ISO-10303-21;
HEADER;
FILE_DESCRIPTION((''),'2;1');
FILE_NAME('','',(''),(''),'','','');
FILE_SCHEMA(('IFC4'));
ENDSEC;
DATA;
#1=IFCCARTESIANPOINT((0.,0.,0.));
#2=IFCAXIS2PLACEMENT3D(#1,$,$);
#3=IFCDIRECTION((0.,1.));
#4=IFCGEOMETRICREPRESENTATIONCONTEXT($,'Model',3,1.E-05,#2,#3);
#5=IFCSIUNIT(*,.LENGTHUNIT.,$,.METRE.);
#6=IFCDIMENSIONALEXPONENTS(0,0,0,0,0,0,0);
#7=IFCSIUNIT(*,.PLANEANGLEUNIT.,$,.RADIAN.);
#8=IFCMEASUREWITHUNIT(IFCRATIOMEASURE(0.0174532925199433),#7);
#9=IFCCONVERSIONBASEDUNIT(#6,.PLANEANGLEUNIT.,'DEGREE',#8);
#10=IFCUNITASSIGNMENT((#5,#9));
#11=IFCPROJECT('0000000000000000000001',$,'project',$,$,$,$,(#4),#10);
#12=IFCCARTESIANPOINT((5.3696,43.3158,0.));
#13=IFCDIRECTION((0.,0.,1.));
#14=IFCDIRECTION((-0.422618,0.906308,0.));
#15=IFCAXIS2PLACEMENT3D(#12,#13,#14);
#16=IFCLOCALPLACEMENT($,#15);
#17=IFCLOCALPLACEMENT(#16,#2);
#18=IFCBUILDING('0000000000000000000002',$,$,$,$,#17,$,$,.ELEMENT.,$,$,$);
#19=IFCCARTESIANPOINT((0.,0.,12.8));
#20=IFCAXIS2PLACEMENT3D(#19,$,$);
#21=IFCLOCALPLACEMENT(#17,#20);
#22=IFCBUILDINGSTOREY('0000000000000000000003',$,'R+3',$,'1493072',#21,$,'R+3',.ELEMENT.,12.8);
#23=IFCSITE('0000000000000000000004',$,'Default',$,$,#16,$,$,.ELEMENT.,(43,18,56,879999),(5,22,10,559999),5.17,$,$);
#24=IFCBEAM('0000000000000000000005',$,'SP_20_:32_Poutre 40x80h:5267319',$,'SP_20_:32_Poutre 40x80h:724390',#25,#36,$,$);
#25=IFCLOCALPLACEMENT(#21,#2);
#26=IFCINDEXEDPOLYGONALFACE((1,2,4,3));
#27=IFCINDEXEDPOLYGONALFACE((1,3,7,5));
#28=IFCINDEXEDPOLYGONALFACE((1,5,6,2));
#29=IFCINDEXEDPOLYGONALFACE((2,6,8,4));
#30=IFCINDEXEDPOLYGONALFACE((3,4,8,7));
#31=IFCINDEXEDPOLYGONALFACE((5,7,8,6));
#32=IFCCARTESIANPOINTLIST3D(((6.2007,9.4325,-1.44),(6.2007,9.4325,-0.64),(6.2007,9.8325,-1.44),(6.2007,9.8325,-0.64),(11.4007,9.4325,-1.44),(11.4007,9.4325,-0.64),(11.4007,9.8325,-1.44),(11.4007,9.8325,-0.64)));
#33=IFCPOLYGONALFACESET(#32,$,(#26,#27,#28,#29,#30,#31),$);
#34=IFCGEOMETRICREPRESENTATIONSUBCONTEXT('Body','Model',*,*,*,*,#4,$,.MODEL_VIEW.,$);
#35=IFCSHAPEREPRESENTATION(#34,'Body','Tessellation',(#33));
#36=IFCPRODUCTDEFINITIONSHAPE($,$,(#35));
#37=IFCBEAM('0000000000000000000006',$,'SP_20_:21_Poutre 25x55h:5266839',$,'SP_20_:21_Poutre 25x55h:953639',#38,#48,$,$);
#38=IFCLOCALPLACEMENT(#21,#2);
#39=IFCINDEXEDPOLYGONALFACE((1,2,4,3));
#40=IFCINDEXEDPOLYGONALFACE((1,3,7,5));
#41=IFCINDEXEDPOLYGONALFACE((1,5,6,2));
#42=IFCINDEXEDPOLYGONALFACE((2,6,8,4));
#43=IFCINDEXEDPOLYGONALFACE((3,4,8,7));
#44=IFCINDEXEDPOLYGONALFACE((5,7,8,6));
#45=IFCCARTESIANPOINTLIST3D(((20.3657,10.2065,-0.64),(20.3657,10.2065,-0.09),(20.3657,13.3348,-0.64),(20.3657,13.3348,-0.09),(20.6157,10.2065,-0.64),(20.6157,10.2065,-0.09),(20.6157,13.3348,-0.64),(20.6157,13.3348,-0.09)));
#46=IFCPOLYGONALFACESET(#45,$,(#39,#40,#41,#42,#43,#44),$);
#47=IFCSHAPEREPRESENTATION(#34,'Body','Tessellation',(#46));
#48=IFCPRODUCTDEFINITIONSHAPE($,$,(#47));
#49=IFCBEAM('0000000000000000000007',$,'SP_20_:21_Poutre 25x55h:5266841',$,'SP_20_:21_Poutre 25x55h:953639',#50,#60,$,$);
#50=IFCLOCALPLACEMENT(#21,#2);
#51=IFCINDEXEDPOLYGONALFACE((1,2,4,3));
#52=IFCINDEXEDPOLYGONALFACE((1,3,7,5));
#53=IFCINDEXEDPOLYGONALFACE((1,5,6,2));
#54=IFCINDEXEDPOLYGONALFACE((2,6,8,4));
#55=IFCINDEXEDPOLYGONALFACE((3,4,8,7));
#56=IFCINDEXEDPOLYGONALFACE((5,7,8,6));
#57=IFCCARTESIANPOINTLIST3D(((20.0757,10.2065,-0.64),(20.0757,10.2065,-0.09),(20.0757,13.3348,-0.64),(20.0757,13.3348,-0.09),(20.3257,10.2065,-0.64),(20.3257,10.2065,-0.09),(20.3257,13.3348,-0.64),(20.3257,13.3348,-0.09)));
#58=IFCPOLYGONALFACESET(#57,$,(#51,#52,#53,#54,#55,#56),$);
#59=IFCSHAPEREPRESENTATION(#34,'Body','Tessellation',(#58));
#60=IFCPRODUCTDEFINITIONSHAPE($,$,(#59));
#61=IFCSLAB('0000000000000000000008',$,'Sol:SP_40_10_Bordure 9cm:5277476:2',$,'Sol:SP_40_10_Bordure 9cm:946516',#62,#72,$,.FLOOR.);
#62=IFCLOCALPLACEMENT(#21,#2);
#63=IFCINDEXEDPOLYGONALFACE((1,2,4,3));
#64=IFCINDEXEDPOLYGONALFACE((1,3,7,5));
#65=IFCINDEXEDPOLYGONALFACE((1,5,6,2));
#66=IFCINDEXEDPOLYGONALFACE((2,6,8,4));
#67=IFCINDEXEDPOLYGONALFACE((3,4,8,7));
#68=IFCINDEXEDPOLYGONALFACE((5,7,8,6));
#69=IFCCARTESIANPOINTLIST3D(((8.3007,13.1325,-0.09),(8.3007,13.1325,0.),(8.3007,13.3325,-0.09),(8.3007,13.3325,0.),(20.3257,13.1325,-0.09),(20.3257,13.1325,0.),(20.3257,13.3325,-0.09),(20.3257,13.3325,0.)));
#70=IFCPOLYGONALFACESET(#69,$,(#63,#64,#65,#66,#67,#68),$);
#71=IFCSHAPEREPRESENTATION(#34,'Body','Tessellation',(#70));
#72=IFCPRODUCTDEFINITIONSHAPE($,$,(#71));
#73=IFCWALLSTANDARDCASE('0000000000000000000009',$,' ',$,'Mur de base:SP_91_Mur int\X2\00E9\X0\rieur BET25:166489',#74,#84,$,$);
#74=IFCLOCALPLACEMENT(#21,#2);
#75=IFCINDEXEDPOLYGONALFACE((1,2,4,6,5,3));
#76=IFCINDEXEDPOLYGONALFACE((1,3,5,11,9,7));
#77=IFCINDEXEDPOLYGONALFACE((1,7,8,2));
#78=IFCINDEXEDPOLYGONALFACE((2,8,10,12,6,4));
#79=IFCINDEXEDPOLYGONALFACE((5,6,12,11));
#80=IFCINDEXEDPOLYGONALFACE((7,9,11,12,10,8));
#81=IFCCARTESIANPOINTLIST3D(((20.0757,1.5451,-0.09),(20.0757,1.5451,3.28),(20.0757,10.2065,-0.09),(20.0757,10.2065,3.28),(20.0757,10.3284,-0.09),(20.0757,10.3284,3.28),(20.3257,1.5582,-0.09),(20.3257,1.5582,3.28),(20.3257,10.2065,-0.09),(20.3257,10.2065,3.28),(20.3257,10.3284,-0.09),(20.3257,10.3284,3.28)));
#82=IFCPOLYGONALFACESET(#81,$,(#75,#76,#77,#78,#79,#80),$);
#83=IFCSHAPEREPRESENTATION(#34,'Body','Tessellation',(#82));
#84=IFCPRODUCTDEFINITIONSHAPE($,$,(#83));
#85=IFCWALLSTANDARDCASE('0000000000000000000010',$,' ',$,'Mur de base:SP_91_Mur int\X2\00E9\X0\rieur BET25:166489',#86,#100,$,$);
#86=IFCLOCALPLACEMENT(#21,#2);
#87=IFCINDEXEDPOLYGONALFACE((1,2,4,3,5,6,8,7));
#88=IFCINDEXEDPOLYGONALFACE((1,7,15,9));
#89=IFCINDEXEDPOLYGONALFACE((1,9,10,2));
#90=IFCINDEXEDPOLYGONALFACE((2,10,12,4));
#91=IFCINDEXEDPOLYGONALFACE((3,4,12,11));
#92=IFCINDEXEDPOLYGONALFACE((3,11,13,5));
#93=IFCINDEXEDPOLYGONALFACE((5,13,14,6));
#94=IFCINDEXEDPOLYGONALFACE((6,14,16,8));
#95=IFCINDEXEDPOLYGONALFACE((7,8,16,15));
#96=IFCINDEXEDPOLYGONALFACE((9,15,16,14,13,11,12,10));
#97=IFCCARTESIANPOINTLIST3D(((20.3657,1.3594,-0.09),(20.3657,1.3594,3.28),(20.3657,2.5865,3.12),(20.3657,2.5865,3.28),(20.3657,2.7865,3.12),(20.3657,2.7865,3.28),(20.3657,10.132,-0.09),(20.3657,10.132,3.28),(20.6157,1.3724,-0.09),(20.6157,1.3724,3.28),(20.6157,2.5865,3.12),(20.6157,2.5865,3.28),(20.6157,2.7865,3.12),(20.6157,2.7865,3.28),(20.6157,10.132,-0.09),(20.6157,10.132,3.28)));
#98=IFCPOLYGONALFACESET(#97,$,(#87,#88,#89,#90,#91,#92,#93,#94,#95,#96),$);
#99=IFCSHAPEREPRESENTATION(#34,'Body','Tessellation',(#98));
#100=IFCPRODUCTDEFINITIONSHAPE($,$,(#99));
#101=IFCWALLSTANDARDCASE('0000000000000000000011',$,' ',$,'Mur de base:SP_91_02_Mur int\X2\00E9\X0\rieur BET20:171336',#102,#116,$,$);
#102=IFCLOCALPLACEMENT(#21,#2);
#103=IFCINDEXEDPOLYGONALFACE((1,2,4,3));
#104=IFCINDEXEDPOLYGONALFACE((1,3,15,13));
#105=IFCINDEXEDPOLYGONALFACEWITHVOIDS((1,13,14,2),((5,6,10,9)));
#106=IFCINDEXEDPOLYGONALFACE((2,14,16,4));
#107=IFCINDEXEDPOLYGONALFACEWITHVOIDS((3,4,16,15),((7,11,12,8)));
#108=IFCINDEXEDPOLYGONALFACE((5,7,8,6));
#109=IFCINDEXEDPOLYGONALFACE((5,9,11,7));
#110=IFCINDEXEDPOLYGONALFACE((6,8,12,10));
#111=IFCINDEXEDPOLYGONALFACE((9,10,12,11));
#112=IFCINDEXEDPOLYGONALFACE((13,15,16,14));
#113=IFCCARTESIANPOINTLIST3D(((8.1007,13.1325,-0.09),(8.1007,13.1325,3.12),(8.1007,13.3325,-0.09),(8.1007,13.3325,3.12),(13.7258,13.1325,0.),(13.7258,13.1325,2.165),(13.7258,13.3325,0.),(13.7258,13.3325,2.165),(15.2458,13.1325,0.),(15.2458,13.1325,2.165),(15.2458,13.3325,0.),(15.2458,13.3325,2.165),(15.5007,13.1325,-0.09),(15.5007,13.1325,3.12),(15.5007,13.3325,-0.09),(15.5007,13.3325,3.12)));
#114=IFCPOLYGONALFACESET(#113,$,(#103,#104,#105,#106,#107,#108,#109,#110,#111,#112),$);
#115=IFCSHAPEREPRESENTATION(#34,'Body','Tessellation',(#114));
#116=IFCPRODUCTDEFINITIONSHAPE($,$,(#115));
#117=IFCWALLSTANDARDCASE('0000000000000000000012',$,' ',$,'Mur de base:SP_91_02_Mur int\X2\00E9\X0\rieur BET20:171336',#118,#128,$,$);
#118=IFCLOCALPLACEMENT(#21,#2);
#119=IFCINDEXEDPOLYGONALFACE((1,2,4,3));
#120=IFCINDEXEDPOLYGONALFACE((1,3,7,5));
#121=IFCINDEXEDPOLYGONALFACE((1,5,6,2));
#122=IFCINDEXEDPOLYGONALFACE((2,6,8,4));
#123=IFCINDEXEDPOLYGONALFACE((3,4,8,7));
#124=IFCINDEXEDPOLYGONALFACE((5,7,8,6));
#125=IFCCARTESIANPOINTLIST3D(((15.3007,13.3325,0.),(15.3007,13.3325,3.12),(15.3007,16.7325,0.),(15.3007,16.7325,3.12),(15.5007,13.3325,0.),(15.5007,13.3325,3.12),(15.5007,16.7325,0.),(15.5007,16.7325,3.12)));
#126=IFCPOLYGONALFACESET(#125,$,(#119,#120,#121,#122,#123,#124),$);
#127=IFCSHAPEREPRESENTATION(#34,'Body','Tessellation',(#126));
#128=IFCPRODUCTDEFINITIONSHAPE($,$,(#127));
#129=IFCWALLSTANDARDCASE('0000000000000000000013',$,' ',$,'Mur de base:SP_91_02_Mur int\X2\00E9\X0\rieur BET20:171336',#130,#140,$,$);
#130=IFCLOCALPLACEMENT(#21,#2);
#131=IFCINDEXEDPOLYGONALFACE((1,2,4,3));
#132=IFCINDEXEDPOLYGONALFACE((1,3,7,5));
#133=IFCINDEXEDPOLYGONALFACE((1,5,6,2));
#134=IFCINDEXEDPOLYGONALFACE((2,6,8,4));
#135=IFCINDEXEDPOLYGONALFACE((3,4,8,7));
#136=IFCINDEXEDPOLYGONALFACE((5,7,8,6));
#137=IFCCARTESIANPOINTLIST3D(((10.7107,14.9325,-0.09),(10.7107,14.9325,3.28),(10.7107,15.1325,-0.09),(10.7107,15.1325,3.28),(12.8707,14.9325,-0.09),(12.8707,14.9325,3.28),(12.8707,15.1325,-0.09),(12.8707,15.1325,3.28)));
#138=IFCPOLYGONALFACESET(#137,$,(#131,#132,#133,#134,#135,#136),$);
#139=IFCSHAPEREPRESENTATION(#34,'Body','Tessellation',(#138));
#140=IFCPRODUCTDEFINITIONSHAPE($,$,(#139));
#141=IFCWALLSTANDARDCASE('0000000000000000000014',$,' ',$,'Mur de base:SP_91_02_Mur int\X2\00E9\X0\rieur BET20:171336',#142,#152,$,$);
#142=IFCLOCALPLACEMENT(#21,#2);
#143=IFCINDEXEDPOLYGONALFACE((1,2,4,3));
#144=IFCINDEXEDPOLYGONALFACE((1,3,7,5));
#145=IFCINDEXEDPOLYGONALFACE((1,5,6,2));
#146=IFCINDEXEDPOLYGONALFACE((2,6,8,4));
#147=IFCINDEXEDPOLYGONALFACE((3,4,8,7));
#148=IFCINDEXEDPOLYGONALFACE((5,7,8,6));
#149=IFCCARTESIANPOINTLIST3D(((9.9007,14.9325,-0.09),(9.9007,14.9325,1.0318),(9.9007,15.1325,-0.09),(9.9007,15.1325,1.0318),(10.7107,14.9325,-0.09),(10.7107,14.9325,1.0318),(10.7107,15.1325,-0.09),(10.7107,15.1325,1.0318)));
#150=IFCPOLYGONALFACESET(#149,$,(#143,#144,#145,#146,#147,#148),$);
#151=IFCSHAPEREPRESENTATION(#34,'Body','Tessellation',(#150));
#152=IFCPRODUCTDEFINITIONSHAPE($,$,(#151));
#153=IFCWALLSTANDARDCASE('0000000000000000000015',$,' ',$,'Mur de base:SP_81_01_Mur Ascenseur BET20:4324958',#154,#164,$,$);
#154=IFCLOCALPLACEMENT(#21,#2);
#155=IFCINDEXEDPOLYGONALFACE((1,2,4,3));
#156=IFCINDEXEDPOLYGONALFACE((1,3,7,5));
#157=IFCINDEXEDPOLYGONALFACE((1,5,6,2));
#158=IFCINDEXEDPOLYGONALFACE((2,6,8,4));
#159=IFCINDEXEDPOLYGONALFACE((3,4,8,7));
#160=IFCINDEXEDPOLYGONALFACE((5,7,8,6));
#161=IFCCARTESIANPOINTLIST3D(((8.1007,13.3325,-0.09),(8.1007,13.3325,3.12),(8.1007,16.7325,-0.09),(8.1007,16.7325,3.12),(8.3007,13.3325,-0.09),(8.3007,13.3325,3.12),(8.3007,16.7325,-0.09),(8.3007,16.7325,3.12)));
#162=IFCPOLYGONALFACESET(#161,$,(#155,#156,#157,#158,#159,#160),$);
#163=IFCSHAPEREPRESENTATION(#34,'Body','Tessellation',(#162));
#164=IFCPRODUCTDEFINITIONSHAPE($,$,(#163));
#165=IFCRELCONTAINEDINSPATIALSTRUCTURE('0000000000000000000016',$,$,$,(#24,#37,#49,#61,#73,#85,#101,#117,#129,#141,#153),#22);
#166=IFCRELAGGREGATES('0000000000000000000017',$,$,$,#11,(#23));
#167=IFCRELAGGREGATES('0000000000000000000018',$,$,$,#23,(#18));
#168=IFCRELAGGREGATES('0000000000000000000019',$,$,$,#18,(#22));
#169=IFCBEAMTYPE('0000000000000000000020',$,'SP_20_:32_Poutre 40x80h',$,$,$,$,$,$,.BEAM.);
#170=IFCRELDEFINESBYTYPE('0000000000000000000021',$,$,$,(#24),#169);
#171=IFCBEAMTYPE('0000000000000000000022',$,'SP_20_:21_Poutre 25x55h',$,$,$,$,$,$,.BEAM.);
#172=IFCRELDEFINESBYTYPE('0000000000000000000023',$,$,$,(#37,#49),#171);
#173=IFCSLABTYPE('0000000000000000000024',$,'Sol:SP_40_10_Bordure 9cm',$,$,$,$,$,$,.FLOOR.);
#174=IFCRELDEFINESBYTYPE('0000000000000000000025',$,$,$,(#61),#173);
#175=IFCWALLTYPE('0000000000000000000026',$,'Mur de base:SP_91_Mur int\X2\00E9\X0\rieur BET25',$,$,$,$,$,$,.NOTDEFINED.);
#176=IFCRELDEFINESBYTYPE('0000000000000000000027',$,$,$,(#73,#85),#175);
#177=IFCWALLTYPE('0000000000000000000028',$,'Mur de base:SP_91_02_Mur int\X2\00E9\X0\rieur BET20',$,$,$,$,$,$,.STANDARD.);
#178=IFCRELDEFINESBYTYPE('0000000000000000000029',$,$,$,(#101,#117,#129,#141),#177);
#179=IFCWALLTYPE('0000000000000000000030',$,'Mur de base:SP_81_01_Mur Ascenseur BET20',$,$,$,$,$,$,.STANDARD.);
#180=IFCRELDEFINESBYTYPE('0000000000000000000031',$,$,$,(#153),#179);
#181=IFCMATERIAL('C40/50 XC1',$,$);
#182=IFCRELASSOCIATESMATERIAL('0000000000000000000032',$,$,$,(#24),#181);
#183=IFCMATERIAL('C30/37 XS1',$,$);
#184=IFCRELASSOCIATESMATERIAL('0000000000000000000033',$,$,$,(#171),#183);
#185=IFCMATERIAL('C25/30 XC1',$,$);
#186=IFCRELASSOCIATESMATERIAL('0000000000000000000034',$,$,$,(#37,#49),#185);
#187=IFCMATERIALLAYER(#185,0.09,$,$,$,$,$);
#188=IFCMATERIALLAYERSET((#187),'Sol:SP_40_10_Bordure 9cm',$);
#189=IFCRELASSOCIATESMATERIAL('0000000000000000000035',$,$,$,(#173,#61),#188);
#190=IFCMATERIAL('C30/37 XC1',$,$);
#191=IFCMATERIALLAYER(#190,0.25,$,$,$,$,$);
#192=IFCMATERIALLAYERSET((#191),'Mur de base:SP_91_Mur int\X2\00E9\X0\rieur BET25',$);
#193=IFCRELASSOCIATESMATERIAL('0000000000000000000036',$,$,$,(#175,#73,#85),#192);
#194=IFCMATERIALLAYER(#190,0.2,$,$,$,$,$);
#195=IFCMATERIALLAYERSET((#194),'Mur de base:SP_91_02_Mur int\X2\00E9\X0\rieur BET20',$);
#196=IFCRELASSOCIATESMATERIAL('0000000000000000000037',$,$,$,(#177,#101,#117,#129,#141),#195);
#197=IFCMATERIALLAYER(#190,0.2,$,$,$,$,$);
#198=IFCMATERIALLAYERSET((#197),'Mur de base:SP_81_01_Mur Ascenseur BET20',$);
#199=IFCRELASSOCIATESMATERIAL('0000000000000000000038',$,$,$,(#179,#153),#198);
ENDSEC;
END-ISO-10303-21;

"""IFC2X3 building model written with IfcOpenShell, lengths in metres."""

from ifc_helpers import new_model, entity, si_unit, converted_unit, direction, frame, frame_2d, origin, origin_2d_with_axis, place, context, subcontext, project, spatial, polyline, rectangle, outline, extrude, clip, bounded_halfspace, material, layer, layer_set, layer_usage, type_object, element, save


model = new_model("IFC2X3")

# Units and contexts
model_context = context("Model", 3, precision=1e-05, world=origin(), true_north=direction((0.0, 1.0)))
body_context = subcontext(model_context, "Body", "Model", "MODEL_VIEW")
ifc_project = project(units=[si_unit("LENGTHUNIT", "METRE"), converted_unit("PLANEANGLEUNIT", "DEGREE", entity("IfcRatioMeasure", 0.0174532925199433), si_unit("PLANEANGLEUNIT", "RADIAN"), dimensions=[0, 0, 0, 0, 0, 0, 0])], contexts=[model_context])

# Site, building, storey
site_placement = place(None, frame((5.3696, 43.3158, 0.0), z_axis=(0.0, 0.0, 1.0), x_axis=(-0.422618, 0.906308, 0.0)))
site = spatial("IfcSite", under=ifc_project, at=site_placement, Name="Default", CompositionType="ELEMENT", RefLatitude=(43, 18, 56, 879999), RefLongitude=(5, 22, 10, 559999), RefElevation=5.17)
building_placement = place(site_placement, origin())
building = spatial("IfcBuilding", under=site, at=building_placement, CompositionType="ELEMENT")
storey_placement = place(building_placement, frame((0.0, 0.0, 12.8)))
storey = spatial("IfcBuildingStorey", under=building, at=storey_placement, Name="R+3", ObjectType="1493072", LongName="R+3", CompositionType="ELEMENT", Elevation=12.8)

# Beams
ifc_material_1 = material(Name="C40/50 XC1")
beam_type_1 = type_object("IfcBeamType", Name="SP_20_:32_Poutre 40x80h", PredefinedType="BEAM")
beam_1_placement = place(storey_placement, frame((11.4007, 9.6325, -0.64), z_axis=(0.0, 0.0, 1.0), x_axis=(-1.0, 0.0, 0.0)))
element("IfcBeam", 1, at=beam_1_placement, inside=storey, type_object=beam_type_1, material=ifc_material_1, Name="SP_20_:32_Poutre 40x80h:5267319", ObjectType="SP_20_:32_Poutre 40x80h:724390", context=body_context, shape_type="SweptSolid", body=[
    extrude(rectangle(XDim=0.8, YDim=0.4, at=frame_2d((0.0, 0.0), x_axis=(1.0, 0.0))), frame((0.0, 0.0, -0.4), z_axis=(1.0, 0.0, 0.0), x_axis=(0.0, 0.0, -1.0)), (0.0, 0.0, 1.0), 5.2),
])
ifc_material_2 = material(Name="C25/30 XC1")
ifc_material_3 = material(Name="C30/37 XS1")
beam_type_2 = type_object("IfcBeamType", Name="SP_20_:21_Poutre 25x55h", PredefinedType="BEAM", material=ifc_material_3)
beam_2_placement = place(storey_placement, frame((20.4907, 13.3221, -0.09), z_axis=(0.0, 0.0, 1.0), x_axis=(0.0, -1.0, 0.0)))
element("IfcBeam", 2, at=beam_2_placement, inside=storey, type_object=beam_type_2, material=ifc_material_2, Name="SP_20_:21_Poutre 25x55h:5266839", ObjectType="SP_20_:21_Poutre 25x55h:953639", context=body_context, shape_type="SweptSolid", body=[
    extrude(rectangle(XDim=0.55, YDim=0.25, at=origin_2d_with_axis()), frame((-0.0127, 0.0, -0.275), z_axis=(1.0, 0.0, 0.0), x_axis=(0.0, 0.0, -1.0)), (0.0, 0.0, 1.0), 3.1283),
])
beam_3_placement = place(storey_placement, frame((20.2007, 13.3221, -0.09), z_axis=(0.0, 0.0, 1.0), x_axis=(0.0, -1.0, 0.0)))
element("IfcBeam", 3, at=beam_3_placement, inside=storey, type_object=beam_type_2, material=ifc_material_2, Name="SP_20_:21_Poutre 25x55h:5266841", ObjectType="SP_20_:21_Poutre 25x55h:953639", context=body_context, shape_type="SweptSolid", body=[
    extrude(rectangle(XDim=0.55, YDim=0.25, at=frame_2d((0.0, 0.0), x_axis=(1.0, 0.0))), frame((-0.0127, 0.0, -0.275), z_axis=(1.0, 0.0, 0.0), x_axis=(0.0, 0.0, -1.0)), (0.0, 0.0, 1.0), 3.1283),
])

# Slab
ifc_layer_1 = layer(ifc_material_2, 0.09)
ifc_layer_set_1 = layer_set([ifc_layer_1], Name="Sol:SP_40_10_Bordure 9cm")
ifc_layer_usage_1 = layer_usage(ifc_layer_set_1, "AXIS3", "POSITIVE", 0.0)
slab_type = type_object("IfcSlabType", Name="Sol:SP_40_10_Bordure 9cm", PredefinedType="FLOOR", material=ifc_layer_set_1)
slab_1_placement = place(storey_placement, frame((8.3007, 13.1325, -0.09)))
element("IfcSlab", 4, at=slab_1_placement, inside=storey, type_object=slab_type, material=ifc_layer_usage_1, Name="Sol:SP_40_10_Bordure 9cm:5277476:2", ObjectType="Sol:SP_40_10_Bordure 9cm:946516", PredefinedType="FLOOR", context=body_context, shape_type="SweptSolid", body=[
    extrude(rectangle(XDim=12.025, YDim=0.2, at=frame_2d((13.075, 0.0), x_axis=(-1.0, 0.0))), frame((19.0875, 0.1, 0.09), z_axis=(0.0, 0.0, -1.0), x_axis=(-1.0, 0.0, 0.0)), (0.0, 0.0, 1.0), 0.09),
])

# Walls
ifc_material_4 = material(Name="C30/37 XC1")
ifc_layer_2 = layer(ifc_material_4, 0.25)
ifc_layer_set_2 = layer_set([ifc_layer_2], Name="Mur de base:SP_91_Mur intérieur BET25")
ifc_layer_usage_2 = layer_usage(ifc_layer_set_2, "AXIS2", "NEGATIVE", 0.125)
wall_type_1 = type_object("IfcWallType", Name="Mur de base:SP_91_Mur intérieur BET25", PredefinedType="NOTDEFINED", material=ifc_layer_set_2)
wall_1_placement = place(storey_placement, frame((20.2007, 10.3284, -0.09), z_axis=(0.0, 0.0, 1.0), x_axis=(0.0, -1.0, 0.0)))
element("IfcWallStandardCase", 5, at=wall_1_placement, inside=storey, type_object=wall_type_1, material=ifc_layer_usage_2, Name=" ", ObjectType="Mur de base:SP_91_Mur intérieur BET25:166489", context=body_context, shape_type="SweptSolid", body=[
    extrude(outline(polyline([(8.7833, -0.125), (8.7702, 0.125), (0.1219, 0.125), (0.0, 0.125), (0.0, -0.125), (0.1219, -0.125), (8.7833, -0.125)])), origin(), (0.0, 0.0, 1.0), 3.37),
])
ifc_layer_usage_3 = layer_usage(ifc_layer_set_2, "AXIS2", "NEGATIVE", 0.125)
wall_2_placement = place(storey_placement, frame((20.4907, 10.132, -0.09), z_axis=(0.0, 0.0, 1.0), x_axis=(0.0, -1.0, 0.0)))
element("IfcWallStandardCase", 6, at=wall_2_placement, inside=storey, type_object=wall_type_1, material=ifc_layer_usage_3, Name=" ", ObjectType="Mur de base:SP_91_Mur intérieur BET25:166489", context=body_context, shape_type="Clipping", body=[
    clip(extrude(outline(polyline([(8.7726, -0.125), (8.7596, 0.125), (8.5593, 0.125), (0.0, 0.125), (0.0, -0.125), (8.7726, -0.125)])), origin(), (0.0, 0.0, 1.0), 3.37), bounded_halfspace(frame((7.3455, 0.125, 3.21), z_axis=(0.0, 0.0, -1.0), x_axis=(1.0, 0.0, 0.0)), True, frame((7.3455, 0.125, 3.21), z_axis=(0.0, 0.0, -1.0), x_axis=(1.0, 0.0, 0.0)), polyline([(0.0, 0.0), (0.2, 0.0), (0.2, 0.25), (0.0, 0.25), (0.0, 0.0)]))),
])

# Wall, opening
ifc_layer_3 = layer(ifc_material_4, 0.2)
ifc_layer_set_3 = layer_set([ifc_layer_3], Name="Mur de base:SP_91_02_Mur intérieur BET20")
ifc_layer_usage_4 = layer_usage(ifc_layer_set_3, "AXIS2", "NEGATIVE", 0.1)
wall_type_2 = type_object("IfcWallType", Name="Mur de base:SP_91_02_Mur intérieur BET20", PredefinedType="STANDARD", material=ifc_layer_set_3)
wall_3_placement = place(storey_placement, frame((8.1007, 13.2325, -0.09)))
wall_3 = element("IfcWallStandardCase", 7, at=wall_3_placement, inside=storey, type_object=wall_type_2, material=ifc_layer_usage_4, Name=" ", ObjectType="Mur de base:SP_91_02_Mur intérieur BET20:171336", context=body_context, shape_type="Clipping", body=[
    clip(extrude(rectangle(XDim=7.4, YDim=0.2, at=frame_2d((3.7, 0.0), x_axis=(-1.0, 0.0))), origin(), (0.0, 0.0, 1.0), 3.21), bounded_halfspace(frame((0.0, -0.1, 3.21), z_axis=(0.0, 0.0, -1.0), x_axis=(1.0, 0.0, 0.0)), True, frame((0.0, -0.1, 3.21), z_axis=(0.0, 0.0, -1.0), x_axis=(1.0, 0.0, 0.0)), polyline([(0.0, 0.0), (0.0, -0.2), (0.2, -0.2), (7.2, -0.2), (7.4, -0.2), (7.4, 0.0), (0.0, 0.0)]))),
])
opening_1_placement = place(wall_3_placement, origin())
element("IfcOpeningElement", 8, at=opening_1_placement, cuts=wall_3, ObjectType="Opening", context=body_context, shape_type="SweptSolid", body=[
    extrude(rectangle(XDim=2.165, YDim=1.52, at=frame_2d((0.0, 0.0), x_axis=(1.0, 0.0))), frame((6.3851, -1.424, 1.1725), z_axis=(0.0, 1.0, 0.0), x_axis=(0.0, 0.0, -1.0)), (0.0, 0.0, 1.0), 3.048),
])

# Walls
ifc_layer_usage_5 = layer_usage(ifc_layer_set_3, "AXIS2", "NEGATIVE", 0.1)
wall_4_placement = place(storey_placement, frame((15.4007, 13.3325, 0.0), z_axis=(0.0, 0.0, 1.0), x_axis=(0.0, 1.0, 0.0)))
element("IfcWallStandardCase", 9, at=wall_4_placement, inside=storey, type_object=wall_type_2, material=ifc_layer_usage_5, Name=" ", ObjectType="Mur de base:SP_91_02_Mur intérieur BET20:171336", context=body_context, shape_type="Clipping", body=[
    clip(clip(extrude(rectangle(XDim=3.4, YDim=0.2, at=frame_2d((1.7, 0.0), x_axis=(-1.0, 0.0))), origin(), (0.0, 0.0, 1.0), 3.12), bounded_halfspace(frame((3.4, -0.1, 3.12), z_axis=(0.0, 0.0, -1.0), x_axis=(1.0, 0.0, 0.0)), True, frame((3.4, -0.1, 3.12), z_axis=(0.0, 0.0, -1.0), x_axis=(1.0, 0.0, 0.0)), polyline([(0.0, 0.0), (-2.9141, 0.0), (-3.4, 0.0), (-3.4, -0.2), (0.0, -0.2), (0.0, 0.0)]))), bounded_halfspace(frame((3.4, -0.1, 0.0)), True, frame((3.4, -0.1, 0.0)), polyline([(0.0, 0.0), (0.0, 0.2), (-3.4, 0.2), (-3.4, 0.0), (0.0, 0.0)]))),
])
ifc_layer_usage_6 = layer_usage(ifc_layer_set_3, "AXIS2", "NEGATIVE", 0.1)
wall_5_placement = place(storey_placement, frame((12.8707, 15.0325, -0.09), z_axis=(0.0, 0.0, 1.0), x_axis=(-1.0, 0.0, 0.0)))
element("IfcWallStandardCase", 10, at=wall_5_placement, inside=storey, type_object=wall_type_2, material=ifc_layer_usage_6, Name=" ", ObjectType="Mur de base:SP_91_02_Mur intérieur BET20:171336", context=body_context, shape_type="SweptSolid", body=[
    extrude(rectangle(XDim=2.16, YDim=0.2, at=frame_2d((1.08, 0.0), x_axis=(-1.0, 0.0))), origin(), (0.0, 0.0, 1.0), 3.37),
])
ifc_layer_usage_7 = layer_usage(ifc_layer_set_3, "AXIS2", "NEGATIVE", 0.1)
wall_6_placement = place(storey_placement, frame((10.7107, 15.0325, -0.09), z_axis=(0.0, 0.0, 1.0), x_axis=(-1.0, 0.0, 0.0)))
element("IfcWallStandardCase", 11, at=wall_6_placement, inside=storey, type_object=wall_type_2, material=ifc_layer_usage_7, Name=" ", ObjectType="Mur de base:SP_91_02_Mur intérieur BET20:171336", context=body_context, shape_type="SweptSolid", body=[
    extrude(rectangle(XDim=0.81, YDim=0.2, at=frame_2d((0.405, 0.0), x_axis=(-1.0, 0.0))), origin(), (0.0, 0.0, 1.0), 1.1218),
])
ifc_layer_4 = layer(ifc_material_4, 0.2)
ifc_layer_set_4 = layer_set([ifc_layer_4], Name="Mur de base:SP_81_01_Mur Ascenseur BET20")
ifc_layer_usage_8 = layer_usage(ifc_layer_set_4, "AXIS2", "NEGATIVE", 0.1)
wall_type_3 = type_object("IfcWallType", Name="Mur de base:SP_81_01_Mur Ascenseur BET20", PredefinedType="STANDARD", material=ifc_layer_set_4)
wall_7_placement = place(storey_placement, frame((8.2007, 16.7325, -0.09), z_axis=(0.0, 0.0, 1.0), x_axis=(0.0, -1.0, 0.0)))
element("IfcWallStandardCase", 12, at=wall_7_placement, inside=storey, type_object=wall_type_3, material=ifc_layer_usage_8, Name=" ", ObjectType="Mur de base:SP_81_01_Mur Ascenseur BET20:4324958", context=body_context, shape_type="Clipping", body=[
    clip(extrude(rectangle(XDim=3.4, YDim=0.2, at=frame_2d((1.7, 0.0), x_axis=(-1.0, 0.0))), origin(), (0.0, 0.0, 1.0), 3.21), bounded_halfspace(frame((3.4, -0.1, 3.21), z_axis=(0.0, 0.0, -1.0), x_axis=(0.0, 1.0, 0.0)), True, frame((3.4, -0.1, 3.21), z_axis=(0.0, 0.0, -1.0), x_axis=(0.0, 1.0, 0.0)), polyline([(0.0, 0.0), (0.0, -3.4), (0.2, -3.4), (0.2, 0.0), (0.0, 0.0)]))),
])

save(model, "model.ifc")
